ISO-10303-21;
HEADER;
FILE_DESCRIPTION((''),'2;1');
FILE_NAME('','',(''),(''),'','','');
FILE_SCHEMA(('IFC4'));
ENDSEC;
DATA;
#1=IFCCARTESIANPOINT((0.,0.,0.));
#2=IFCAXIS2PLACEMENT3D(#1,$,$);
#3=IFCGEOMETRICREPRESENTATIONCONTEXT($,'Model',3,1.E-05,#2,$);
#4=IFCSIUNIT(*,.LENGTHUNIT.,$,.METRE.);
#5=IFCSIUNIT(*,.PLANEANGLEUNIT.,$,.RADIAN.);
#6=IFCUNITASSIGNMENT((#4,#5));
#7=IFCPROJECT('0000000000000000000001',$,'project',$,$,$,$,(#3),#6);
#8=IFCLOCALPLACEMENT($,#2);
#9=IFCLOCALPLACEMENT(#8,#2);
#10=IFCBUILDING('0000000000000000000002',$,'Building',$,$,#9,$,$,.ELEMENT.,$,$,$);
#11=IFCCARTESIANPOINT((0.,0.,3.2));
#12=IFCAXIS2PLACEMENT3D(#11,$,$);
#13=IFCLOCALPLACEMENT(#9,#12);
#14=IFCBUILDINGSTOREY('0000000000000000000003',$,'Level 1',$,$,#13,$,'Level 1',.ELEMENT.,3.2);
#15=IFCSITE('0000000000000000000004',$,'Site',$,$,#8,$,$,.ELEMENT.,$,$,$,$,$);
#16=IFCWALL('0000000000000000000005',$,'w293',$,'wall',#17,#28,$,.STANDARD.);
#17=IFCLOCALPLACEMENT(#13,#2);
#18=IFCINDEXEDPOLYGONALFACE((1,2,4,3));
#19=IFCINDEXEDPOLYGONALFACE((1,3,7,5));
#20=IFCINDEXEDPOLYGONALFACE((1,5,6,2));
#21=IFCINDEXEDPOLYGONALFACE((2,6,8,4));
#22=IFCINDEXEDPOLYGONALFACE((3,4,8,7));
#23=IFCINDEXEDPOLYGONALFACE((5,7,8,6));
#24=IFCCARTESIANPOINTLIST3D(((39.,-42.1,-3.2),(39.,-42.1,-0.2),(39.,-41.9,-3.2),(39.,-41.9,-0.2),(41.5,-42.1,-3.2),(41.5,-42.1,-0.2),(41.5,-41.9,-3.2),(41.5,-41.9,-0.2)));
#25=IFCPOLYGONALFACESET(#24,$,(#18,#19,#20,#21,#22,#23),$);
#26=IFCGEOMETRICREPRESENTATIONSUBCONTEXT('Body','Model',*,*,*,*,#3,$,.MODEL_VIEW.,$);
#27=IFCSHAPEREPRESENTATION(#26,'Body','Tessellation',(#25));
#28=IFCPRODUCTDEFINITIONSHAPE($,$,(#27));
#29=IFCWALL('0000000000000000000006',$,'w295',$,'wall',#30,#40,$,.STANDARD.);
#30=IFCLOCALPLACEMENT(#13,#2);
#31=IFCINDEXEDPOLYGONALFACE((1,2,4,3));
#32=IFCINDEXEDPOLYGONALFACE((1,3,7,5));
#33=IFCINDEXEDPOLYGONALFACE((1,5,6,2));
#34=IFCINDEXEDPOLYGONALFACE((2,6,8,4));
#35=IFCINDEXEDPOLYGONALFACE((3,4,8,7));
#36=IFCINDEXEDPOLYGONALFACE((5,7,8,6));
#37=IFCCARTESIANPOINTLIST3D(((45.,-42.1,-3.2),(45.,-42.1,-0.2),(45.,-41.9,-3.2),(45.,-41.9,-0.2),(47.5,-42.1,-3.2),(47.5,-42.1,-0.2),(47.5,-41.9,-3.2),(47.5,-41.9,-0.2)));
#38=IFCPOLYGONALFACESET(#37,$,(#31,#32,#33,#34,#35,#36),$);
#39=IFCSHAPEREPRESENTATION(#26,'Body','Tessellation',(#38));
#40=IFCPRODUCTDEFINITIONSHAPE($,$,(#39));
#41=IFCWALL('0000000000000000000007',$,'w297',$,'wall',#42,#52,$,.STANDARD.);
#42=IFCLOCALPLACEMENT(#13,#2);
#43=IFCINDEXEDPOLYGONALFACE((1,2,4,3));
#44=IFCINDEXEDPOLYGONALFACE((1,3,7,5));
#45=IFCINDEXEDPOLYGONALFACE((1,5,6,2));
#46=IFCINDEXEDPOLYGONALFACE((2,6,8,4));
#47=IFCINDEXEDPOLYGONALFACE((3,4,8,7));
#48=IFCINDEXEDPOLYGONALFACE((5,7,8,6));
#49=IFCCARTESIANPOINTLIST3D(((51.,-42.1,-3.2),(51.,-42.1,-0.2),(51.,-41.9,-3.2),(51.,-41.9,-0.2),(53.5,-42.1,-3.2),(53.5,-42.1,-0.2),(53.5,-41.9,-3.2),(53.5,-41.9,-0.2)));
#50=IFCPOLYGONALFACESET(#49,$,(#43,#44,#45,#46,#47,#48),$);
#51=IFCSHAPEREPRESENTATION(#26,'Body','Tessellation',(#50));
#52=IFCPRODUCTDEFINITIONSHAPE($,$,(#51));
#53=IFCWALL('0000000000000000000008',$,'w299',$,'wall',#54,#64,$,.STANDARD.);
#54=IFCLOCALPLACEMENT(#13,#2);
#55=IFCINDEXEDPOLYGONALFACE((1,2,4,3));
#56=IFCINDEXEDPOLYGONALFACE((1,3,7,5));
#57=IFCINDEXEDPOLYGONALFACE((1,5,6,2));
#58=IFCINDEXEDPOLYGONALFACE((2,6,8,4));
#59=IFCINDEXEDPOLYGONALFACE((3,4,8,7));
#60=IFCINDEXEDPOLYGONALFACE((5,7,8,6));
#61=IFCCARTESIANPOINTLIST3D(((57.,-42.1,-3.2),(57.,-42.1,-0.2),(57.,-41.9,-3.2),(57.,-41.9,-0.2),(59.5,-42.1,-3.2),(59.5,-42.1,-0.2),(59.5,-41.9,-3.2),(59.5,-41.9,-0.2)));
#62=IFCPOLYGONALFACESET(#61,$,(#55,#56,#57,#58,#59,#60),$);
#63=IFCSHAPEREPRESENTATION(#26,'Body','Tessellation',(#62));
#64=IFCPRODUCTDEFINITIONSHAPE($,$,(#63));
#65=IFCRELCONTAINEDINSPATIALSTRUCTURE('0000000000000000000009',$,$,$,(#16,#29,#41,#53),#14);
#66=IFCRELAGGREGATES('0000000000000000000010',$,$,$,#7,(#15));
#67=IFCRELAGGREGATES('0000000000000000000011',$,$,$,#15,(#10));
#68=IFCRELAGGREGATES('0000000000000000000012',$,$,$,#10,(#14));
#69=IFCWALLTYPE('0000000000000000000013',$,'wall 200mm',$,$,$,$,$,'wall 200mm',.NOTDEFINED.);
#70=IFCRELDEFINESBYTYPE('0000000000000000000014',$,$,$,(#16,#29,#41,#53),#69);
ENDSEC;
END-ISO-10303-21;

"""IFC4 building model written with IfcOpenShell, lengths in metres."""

from ifc_helpers import new_model, si_unit, frame, frame_2d, origin, place, context, subcontext, project, spatial, rectangle, extrude, type_object, element, save


model = new_model("IFC4")

# Units and contexts
model_context = context("Model", 3, precision=1e-05, world=origin())
body_context = subcontext(model_context, "Body", "Model", "MODEL_VIEW")
ifc_project = project(units=[si_unit("LENGTHUNIT", "METRE"), si_unit("PLANEANGLEUNIT", "RADIAN")], contexts=[model_context])

# Site, building, storey
site_placement = place(None, origin())
site = spatial("IfcSite", under=ifc_project, at=site_placement, Name="Site", CompositionType="ELEMENT")
building_placement = place(site_placement, origin())
building = spatial("IfcBuilding", under=site, at=building_placement, Name="Building", CompositionType="ELEMENT")
storey_placement = place(building_placement, frame((0.0, 0.0, 3.2)))
storey = spatial("IfcBuildingStorey", under=building, at=storey_placement, Name="Level 1", LongName="Level 1", CompositionType="ELEMENT", Elevation=3.2)

# Walls
wall_type = type_object("IfcWallType", Name="wall 200mm", ElementType="wall 200mm", PredefinedType="NOTDEFINED")
for number, where, z_axis, x_axis, name in (
    (1, (39.0, -42.0, -3.2), (0.0, 0.0, 1.0), (1.0, 0.0, 0.0), "w293"),
    (2, (45.0, -42.0, -3.2), (0.0, 0.0, 1.0), (1.0, 0.0, 0.0), "w295"),
    (3, (51.0, -42.0, -3.2), (0.0, 0.0, 1.0), (1.0, 0.0, 0.0), "w297"),
    (4, (57.0, -42.0, -3.2), (0.0, 0.0, 1.0), (1.0, 0.0, 0.0), "w299"),
):
    element("IfcWall", number, at=place(storey_placement, frame(where, z_axis=z_axis, x_axis=x_axis)), inside=storey, type_object=wall_type, Name=name, ObjectType="wall", PredefinedType="STANDARD", context=body_context, shape_type="SweptSolid", body=[
        extrude(rectangle(XDim=2.5, YDim=0.2, at=frame_2d((1.25, 0.0))), origin(), (0.0, 0.0, 1.0), 3.0),
    ])

save(model, "model.ifc")
